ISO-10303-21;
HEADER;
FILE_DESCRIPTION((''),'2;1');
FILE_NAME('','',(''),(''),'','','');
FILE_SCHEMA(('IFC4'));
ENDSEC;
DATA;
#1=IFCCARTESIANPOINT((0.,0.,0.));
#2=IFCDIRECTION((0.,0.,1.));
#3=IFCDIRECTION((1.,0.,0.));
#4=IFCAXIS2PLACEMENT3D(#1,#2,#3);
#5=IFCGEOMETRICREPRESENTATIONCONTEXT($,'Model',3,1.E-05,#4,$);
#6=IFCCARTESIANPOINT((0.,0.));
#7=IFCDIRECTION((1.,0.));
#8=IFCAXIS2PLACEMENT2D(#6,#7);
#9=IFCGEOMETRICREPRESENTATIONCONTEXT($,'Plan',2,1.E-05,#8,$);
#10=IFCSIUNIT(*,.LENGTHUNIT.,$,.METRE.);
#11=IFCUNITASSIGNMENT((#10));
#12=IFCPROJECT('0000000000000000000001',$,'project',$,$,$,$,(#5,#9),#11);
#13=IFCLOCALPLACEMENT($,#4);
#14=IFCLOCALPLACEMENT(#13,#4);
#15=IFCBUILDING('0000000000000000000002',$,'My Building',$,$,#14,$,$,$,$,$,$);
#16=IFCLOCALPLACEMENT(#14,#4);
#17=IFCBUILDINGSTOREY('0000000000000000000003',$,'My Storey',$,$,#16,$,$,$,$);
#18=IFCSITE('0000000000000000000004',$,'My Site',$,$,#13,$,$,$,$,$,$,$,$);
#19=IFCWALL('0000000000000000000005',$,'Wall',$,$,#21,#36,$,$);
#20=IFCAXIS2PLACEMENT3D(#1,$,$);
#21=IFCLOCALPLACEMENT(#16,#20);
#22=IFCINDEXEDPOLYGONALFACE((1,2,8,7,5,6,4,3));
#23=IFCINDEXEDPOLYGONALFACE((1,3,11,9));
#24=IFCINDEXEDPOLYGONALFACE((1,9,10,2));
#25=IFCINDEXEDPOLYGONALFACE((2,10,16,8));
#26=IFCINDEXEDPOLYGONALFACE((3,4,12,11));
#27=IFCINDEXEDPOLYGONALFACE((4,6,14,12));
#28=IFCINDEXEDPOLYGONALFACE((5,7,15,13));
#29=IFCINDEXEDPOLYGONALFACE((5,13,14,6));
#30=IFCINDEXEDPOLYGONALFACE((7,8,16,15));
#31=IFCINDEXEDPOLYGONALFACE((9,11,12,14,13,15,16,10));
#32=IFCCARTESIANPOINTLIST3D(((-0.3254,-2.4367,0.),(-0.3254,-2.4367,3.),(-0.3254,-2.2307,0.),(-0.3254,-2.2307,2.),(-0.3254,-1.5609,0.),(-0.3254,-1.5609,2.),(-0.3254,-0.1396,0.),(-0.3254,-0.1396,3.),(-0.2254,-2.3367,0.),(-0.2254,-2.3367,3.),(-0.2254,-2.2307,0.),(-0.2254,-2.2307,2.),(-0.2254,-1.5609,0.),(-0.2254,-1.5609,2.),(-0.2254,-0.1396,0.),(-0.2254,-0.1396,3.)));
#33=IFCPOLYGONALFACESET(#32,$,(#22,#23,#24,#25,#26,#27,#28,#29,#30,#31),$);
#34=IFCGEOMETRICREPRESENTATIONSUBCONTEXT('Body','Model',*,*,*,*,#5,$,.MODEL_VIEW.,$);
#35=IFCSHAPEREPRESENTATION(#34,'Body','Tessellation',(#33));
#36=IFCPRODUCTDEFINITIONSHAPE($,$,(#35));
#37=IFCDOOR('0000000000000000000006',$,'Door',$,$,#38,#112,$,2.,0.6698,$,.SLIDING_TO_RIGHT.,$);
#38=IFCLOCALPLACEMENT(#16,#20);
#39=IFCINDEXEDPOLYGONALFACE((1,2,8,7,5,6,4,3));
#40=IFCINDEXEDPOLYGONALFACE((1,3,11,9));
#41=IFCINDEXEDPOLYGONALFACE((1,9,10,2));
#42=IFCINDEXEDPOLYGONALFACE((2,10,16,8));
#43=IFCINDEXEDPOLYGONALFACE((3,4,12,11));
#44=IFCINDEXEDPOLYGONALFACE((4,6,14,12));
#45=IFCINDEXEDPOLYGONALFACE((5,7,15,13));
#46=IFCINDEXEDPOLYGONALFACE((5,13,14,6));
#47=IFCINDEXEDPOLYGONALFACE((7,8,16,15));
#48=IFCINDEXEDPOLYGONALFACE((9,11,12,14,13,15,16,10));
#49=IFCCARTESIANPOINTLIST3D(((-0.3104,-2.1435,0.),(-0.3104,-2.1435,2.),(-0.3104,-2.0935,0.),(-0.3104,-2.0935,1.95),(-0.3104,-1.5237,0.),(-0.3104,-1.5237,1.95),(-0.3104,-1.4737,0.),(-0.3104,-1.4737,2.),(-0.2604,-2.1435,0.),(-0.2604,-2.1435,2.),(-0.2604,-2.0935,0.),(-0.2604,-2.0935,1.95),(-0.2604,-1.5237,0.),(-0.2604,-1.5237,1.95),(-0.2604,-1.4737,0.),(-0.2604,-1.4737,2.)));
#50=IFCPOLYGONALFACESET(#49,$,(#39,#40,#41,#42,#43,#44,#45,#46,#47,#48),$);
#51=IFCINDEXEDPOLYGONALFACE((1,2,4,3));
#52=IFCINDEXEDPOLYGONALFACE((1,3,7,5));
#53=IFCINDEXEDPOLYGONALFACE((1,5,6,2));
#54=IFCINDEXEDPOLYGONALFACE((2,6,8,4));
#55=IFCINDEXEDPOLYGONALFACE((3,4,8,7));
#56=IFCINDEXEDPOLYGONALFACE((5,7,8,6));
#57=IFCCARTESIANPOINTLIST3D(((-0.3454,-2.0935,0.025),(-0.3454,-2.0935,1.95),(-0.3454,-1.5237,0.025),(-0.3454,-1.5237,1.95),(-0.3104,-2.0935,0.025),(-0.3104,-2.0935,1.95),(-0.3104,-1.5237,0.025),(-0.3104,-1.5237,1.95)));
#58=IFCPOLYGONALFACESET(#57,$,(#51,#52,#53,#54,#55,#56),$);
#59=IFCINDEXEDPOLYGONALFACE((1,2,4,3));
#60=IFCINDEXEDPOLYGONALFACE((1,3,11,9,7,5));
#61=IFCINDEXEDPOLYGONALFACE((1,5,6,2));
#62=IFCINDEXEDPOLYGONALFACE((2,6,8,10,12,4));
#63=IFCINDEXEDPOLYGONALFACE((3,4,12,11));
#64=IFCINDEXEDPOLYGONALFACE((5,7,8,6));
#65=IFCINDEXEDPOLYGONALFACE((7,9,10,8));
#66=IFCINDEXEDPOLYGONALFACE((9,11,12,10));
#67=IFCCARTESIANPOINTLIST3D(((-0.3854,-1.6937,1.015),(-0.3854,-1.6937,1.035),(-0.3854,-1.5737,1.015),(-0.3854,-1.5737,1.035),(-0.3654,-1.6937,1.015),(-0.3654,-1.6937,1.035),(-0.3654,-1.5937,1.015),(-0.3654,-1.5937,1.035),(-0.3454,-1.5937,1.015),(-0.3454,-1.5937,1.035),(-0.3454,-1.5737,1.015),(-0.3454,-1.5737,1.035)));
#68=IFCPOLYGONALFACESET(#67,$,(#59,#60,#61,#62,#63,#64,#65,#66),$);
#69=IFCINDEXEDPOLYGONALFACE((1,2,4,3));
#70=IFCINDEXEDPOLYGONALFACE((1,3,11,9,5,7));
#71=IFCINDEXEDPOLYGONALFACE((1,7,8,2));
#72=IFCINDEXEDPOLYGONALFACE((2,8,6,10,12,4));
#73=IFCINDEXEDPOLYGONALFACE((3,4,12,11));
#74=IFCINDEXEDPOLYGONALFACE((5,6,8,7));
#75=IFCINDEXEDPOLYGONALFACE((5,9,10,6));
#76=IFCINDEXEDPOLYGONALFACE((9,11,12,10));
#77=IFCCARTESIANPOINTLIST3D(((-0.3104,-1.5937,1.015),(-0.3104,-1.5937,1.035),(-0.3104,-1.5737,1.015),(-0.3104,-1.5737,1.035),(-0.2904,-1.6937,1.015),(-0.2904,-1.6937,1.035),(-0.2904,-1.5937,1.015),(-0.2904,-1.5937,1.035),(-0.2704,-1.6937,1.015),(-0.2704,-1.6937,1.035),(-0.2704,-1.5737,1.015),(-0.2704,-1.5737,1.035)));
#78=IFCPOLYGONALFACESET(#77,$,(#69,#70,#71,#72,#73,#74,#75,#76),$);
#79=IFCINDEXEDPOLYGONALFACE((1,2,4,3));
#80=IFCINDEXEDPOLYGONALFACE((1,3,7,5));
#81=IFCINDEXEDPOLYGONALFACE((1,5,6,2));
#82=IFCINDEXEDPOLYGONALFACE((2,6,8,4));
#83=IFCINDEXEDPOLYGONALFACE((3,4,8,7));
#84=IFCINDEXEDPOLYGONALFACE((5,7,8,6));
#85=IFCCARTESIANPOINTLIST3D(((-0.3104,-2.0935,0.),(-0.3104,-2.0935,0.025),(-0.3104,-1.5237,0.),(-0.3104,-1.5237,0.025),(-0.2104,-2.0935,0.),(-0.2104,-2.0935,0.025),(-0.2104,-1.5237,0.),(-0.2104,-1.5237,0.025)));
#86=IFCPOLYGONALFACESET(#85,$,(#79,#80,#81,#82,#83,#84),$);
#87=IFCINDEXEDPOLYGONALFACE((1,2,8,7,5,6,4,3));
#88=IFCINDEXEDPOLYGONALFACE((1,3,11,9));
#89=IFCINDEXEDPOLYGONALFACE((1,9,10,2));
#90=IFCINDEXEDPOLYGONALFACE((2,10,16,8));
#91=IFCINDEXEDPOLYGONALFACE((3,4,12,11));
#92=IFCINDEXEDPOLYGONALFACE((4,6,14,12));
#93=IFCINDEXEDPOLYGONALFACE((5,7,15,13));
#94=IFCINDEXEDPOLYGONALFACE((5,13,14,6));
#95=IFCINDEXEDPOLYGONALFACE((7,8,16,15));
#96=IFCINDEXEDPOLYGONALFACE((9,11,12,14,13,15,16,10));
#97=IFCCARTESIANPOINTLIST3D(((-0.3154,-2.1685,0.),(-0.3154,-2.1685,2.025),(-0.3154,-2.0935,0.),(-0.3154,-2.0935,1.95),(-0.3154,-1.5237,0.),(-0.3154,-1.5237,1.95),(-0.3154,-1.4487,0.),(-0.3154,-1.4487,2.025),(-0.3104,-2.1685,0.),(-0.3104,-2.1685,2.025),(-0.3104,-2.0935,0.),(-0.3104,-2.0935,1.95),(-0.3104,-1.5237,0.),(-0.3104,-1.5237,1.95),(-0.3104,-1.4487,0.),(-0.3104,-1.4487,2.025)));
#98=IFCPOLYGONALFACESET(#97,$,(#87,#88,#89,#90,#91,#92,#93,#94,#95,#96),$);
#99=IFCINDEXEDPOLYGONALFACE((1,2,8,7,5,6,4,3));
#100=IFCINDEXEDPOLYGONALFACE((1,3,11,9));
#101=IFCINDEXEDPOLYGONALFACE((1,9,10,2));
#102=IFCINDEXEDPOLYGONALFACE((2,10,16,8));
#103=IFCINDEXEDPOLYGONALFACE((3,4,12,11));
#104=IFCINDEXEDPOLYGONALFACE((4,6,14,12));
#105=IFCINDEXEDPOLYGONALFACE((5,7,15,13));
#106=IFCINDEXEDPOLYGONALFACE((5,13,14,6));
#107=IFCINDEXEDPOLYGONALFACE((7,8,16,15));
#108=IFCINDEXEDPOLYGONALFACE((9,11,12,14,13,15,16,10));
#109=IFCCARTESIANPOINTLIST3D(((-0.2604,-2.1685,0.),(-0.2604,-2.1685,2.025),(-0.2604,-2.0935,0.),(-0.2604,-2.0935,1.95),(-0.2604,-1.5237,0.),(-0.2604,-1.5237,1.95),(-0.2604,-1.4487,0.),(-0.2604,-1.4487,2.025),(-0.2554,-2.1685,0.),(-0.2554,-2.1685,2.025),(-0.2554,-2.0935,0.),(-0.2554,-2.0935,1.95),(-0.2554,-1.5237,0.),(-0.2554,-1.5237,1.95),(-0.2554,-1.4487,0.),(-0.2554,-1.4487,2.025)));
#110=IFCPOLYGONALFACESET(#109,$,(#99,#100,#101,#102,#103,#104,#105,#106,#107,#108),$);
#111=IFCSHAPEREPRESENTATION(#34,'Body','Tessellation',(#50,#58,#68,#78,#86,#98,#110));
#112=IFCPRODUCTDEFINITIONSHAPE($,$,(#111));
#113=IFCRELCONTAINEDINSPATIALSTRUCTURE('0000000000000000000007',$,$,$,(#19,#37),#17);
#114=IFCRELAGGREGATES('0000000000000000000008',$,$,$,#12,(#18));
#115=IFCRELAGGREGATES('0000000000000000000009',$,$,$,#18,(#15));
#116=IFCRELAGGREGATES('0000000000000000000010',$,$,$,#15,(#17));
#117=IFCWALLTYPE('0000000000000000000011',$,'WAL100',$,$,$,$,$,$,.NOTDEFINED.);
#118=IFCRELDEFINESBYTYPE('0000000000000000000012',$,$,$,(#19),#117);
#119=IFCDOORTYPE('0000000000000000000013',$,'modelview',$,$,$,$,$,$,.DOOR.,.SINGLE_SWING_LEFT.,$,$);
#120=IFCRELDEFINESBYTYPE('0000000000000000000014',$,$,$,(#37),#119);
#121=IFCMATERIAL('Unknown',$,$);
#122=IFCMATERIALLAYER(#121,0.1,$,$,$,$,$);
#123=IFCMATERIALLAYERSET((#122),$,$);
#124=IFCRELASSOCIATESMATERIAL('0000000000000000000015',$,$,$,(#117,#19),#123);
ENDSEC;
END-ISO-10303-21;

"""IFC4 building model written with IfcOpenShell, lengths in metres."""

from ifc_helpers import new_model, entity, si_unit, frame, origin_with_axes, origin_2d_with_axis, place, context, subcontext, project, spatial, line, indexed_curve, outline, extrude, shape, source, transform, mapped, material, layer, layer_set, layer_usage, type_object, type_shapes, element, fill, save


model = new_model("IFC4")

# Units and contexts
model_context = context("Model", 3, precision=1e-05, world=origin_with_axes())
plan_context = context("Plan", 2, precision=1e-05, world=origin_2d_with_axis())
body_context_1 = subcontext(model_context, "Body", "Model", "MODEL_VIEW")
body_context_2 = subcontext(plan_context, "Body", "Plan", "PLAN_VIEW")
ifc_project = project(units=[si_unit("LENGTHUNIT", "METRE")], contexts=[model_context, plan_context])

# Site, building, storey
site_placement = place(None, origin_with_axes())
site = spatial("IfcSite", under=ifc_project, at=site_placement, Name="My Site")
building_placement = place(site_placement, origin_with_axes())
building = spatial("IfcBuilding", under=site, at=building_placement, Name="My Building")
storey_placement = place(building_placement, origin_with_axes())
storey = spatial("IfcBuildingStorey", under=building, at=storey_placement, Name="My Storey")

# Shared definitions
ifc_material = material(Name="Unknown")

# Shared definitions
ifc_layer_1 = layer(ifc_material, 0.1)
ifc_layer_set_1 = layer_set([ifc_layer_1])
wall_type_1 = type_object("IfcWallType", Name="WAL100", PredefinedType="NOTDEFINED", material=ifc_layer_set_1)

# Wall, opening, door
ifc_layer_usage_1 = layer_usage(ifc_layer_set_1, "AXIS2", "POSITIVE", 0.0)
wall_1_placement = place(storey_placement, frame((-0.2254, -2.3367, 0.0), z_axis=(0.0, 0.0, 1.0), x_axis=(0.0, 1.0, 0.0)))
wall_1 = element("IfcWall", 1, at=wall_1_placement, inside=storey, type_object=wall_type_1, material=ifc_layer_usage_1, Name="Wall", context=body_context_1, shape_type="SweptSolid", body=[
    extrude(outline(indexed_curve([(0.0, 0.0), (-0.1, 0.1), (2.197, 0.1), (2.197, 0.0)], segments=[line(1, 2, 3, 4, 1)])), origin_with_axes(), (0.0, 0.0, 1.0), 3.0),
])
shared_shape_1 = source(origin_with_axes(), body_context_1, "Body", "SweptSolid", [
    extrude(outline(indexed_curve([(0.0, 0.0), (0.6698, 0.0), (0.6698, 2.0), (0.0, 2.0)], segments=[line(1, 2, 3, 4, 1)])), frame((0.0, -0.6, 0.0), z_axis=(0.0, -1.0, 0.0), x_axis=(1.0, 0.0, 0.0)), (0.0, 0.0, -1.0), 1.2),
])
opening_1_placement = place(wall_1_placement, frame((0.7758, 0.085, 0.0), z_axis=(0.0, 0.0, 1.0), x_axis=(-1.0, 0.0, 0.0)))
opening_1 = element("IfcOpeningElement", 2, at=opening_1_placement, cuts=wall_1, PredefinedType="OPENING", context=body_context_1, shape_type="MappedRepresentation", body=[
    mapped(shared_shape_1, transform((0.0, 0.0, 0.0), x_axis=(1.0, 0.0, 0.0), y_axis=(0.0, 1.0, 0.0), z_axis=(0.0, 0.0, 1.0), scale=1.0)),
])
door_type_1 = type_object("IfcDoorType", Name="modelview", OperationType="SINGLE_SWING_LEFT", PredefinedType="DOOR")
shared_shape_2 = source(origin_with_axes(), body_context_1, "Body", "SweptSolid", [
    extrude(outline(indexed_curve([(0.0, 0.0), (0.0, 2.0), (0.6698, 2.0), (0.6698, 0.0), (0.6198, 0.0), (0.6198, 1.95), (0.05, 1.95), (0.05, 0.0)], segments=[line(1, 2, 3, 4, 5, 6, 7, 8, 1)])), frame((0.0, 0.0, 0.0), z_axis=(0.0, -1.0, 0.0), x_axis=(1.0, 0.0, 0.0)), (0.0, 0.0, -1.0), 0.05),
    extrude(outline(indexed_curve([(0.0, 0.0), (0.5698, 0.0), (0.5698, 0.035), (0.0, 0.035)], segments=[line(1, 2, 3, 4, 1)])), frame((0.05, -0.035, 0.025), z_axis=(0.0, 0.0, 1.0), x_axis=(1.0, 0.0, 0.0)), (0.0, 0.0, 1.0), 1.925),
    extrude(outline(indexed_curve([(0.0, 0.0), (0.0, -0.04), (0.12, -0.04), (0.12, -0.02), (0.02, -0.02), (0.02, 0.0)], segments=[line(1, 2, 3, 4, 5, 6, 1)])), frame((0.1, -0.035, 1.015), z_axis=(0.0, 0.0, 1.0), x_axis=(1.0, 0.0, 0.0)), (0.0, 0.0, 1.0), 0.02),
    extrude(outline(indexed_curve([(0.0, 0.0), (0.0, 0.04), (0.12, 0.04), (0.12, 0.02), (0.02, 0.02), (0.02, 0.0)], segments=[line(1, 2, 3, 4, 5, 6, 1)])), frame((0.1, 0.0, 1.015), z_axis=(0.0, 0.0, 1.0), x_axis=(1.0, 0.0, 0.0)), (0.0, 0.0, 1.0), 0.02),
    extrude(outline(indexed_curve([(0.0, 0.0), (0.5698, 0.0), (0.5698, 0.1), (0.0, 0.1)], segments=[line(1, 2, 3, 4, 1)])), frame((0.05, 0.0, 0.0), z_axis=(0.0, 0.0, 1.0), x_axis=(1.0, 0.0, 0.0)), (0.0, 0.0, 1.0), 0.025),
    extrude(outline(indexed_curve([(0.0, 0.0), (0.0, 2.025), (0.7198, 2.025), (0.7198, 0.0), (0.6448, 0.0), (0.6448, 1.95), (0.075, 1.95), (0.075, 0.0)], segments=[line(1, 2, 3, 4, 5, 6, 7, 8, 1)])), frame((-0.025, -0.005, 0.0), z_axis=(0.0, -1.0, 0.0), x_axis=(1.0, 0.0, 0.0)), (0.0, 0.0, -1.0), 0.005),
    extrude(outline(indexed_curve([(0.0, 0.0), (0.0, 2.025), (0.7198, 2.025), (0.7198, 0.0), (0.6448, 0.0), (0.6448, 1.95), (0.075, 1.95), (0.075, 0.0)], segments=[line(1, 2, 3, 4, 5, 6, 7, 8, 1)])), frame((-0.025, 0.05, 0.0), z_axis=(0.0, -1.0, 0.0), x_axis=(1.0, 0.0, 0.0)), (0.0, 0.0, -1.0), 0.005),
])
shared_shape_3 = source(origin_with_axes(), body_context_2, "Body", "Curve2D", [
    entity("IfcIndexedPolyCurve", entity("IfcCartesianPointList2D", [[0.0, 0.0], [0.05, 0.0], [0.05, 0.05], [0.0, 0.05]]), [entity("IfcLineIndex", [1, 2, 3, 4, 1])]),
    entity("IfcIndexedPolyCurve", entity("IfcCartesianPointList2D", [[0.6698, 0.0], [0.6198, 0.0], [0.6198, 0.05], [0.6698, 0.05]]), [entity("IfcLineIndex", [1, 2, 3, 4, 1])]),
    entity("IfcIndexedPolyCurve", entity("IfcCartesianPointList2D", [[0.9047, -0.035], [0.3349, -0.035], [0.3349, 0.0], [0.9047, 0.0]]), [entity("IfcLineIndex", [1, 2, 3, 4, 1])]),
])
type_shapes(door_type_1, [shared_shape_2, shared_shape_3])
door_1_placement = place(opening_1_placement, frame((-0.0873, 0.0, 0.0), z_axis=(0.0, 0.0, 1.0), x_axis=(1.0, 0.0, 0.0)))
door_1 = element("IfcDoor", 3, at=door_1_placement, inside=storey, type_object=door_type_1, Name="Door", OperationType="SLIDING_TO_RIGHT", OverallHeight=2.0, OverallWidth=0.6698, shapes=[
    shape(body_context_1, "Body", "MappedRepresentation", [mapped(shared_shape_2, transform((0.0, 0.0, 0.0), x_axis=(1.0, 0.0, 0.0), y_axis=(0.0, 1.0, 0.0), z_axis=(0.0, 0.0, 1.0), scale=1.0))]),
    shape(body_context_2, "Body", "MappedRepresentation", [mapped(shared_shape_3, transform((0.0, 0.0, 0.0), x_axis=(1.0, 0.0, 0.0), y_axis=(0.0, 1.0, 0.0), z_axis=(0.0, 0.0, 1.0), scale=1.0))]),
])
fill(opening_1, door_1)

save(model, "model.ifc")
